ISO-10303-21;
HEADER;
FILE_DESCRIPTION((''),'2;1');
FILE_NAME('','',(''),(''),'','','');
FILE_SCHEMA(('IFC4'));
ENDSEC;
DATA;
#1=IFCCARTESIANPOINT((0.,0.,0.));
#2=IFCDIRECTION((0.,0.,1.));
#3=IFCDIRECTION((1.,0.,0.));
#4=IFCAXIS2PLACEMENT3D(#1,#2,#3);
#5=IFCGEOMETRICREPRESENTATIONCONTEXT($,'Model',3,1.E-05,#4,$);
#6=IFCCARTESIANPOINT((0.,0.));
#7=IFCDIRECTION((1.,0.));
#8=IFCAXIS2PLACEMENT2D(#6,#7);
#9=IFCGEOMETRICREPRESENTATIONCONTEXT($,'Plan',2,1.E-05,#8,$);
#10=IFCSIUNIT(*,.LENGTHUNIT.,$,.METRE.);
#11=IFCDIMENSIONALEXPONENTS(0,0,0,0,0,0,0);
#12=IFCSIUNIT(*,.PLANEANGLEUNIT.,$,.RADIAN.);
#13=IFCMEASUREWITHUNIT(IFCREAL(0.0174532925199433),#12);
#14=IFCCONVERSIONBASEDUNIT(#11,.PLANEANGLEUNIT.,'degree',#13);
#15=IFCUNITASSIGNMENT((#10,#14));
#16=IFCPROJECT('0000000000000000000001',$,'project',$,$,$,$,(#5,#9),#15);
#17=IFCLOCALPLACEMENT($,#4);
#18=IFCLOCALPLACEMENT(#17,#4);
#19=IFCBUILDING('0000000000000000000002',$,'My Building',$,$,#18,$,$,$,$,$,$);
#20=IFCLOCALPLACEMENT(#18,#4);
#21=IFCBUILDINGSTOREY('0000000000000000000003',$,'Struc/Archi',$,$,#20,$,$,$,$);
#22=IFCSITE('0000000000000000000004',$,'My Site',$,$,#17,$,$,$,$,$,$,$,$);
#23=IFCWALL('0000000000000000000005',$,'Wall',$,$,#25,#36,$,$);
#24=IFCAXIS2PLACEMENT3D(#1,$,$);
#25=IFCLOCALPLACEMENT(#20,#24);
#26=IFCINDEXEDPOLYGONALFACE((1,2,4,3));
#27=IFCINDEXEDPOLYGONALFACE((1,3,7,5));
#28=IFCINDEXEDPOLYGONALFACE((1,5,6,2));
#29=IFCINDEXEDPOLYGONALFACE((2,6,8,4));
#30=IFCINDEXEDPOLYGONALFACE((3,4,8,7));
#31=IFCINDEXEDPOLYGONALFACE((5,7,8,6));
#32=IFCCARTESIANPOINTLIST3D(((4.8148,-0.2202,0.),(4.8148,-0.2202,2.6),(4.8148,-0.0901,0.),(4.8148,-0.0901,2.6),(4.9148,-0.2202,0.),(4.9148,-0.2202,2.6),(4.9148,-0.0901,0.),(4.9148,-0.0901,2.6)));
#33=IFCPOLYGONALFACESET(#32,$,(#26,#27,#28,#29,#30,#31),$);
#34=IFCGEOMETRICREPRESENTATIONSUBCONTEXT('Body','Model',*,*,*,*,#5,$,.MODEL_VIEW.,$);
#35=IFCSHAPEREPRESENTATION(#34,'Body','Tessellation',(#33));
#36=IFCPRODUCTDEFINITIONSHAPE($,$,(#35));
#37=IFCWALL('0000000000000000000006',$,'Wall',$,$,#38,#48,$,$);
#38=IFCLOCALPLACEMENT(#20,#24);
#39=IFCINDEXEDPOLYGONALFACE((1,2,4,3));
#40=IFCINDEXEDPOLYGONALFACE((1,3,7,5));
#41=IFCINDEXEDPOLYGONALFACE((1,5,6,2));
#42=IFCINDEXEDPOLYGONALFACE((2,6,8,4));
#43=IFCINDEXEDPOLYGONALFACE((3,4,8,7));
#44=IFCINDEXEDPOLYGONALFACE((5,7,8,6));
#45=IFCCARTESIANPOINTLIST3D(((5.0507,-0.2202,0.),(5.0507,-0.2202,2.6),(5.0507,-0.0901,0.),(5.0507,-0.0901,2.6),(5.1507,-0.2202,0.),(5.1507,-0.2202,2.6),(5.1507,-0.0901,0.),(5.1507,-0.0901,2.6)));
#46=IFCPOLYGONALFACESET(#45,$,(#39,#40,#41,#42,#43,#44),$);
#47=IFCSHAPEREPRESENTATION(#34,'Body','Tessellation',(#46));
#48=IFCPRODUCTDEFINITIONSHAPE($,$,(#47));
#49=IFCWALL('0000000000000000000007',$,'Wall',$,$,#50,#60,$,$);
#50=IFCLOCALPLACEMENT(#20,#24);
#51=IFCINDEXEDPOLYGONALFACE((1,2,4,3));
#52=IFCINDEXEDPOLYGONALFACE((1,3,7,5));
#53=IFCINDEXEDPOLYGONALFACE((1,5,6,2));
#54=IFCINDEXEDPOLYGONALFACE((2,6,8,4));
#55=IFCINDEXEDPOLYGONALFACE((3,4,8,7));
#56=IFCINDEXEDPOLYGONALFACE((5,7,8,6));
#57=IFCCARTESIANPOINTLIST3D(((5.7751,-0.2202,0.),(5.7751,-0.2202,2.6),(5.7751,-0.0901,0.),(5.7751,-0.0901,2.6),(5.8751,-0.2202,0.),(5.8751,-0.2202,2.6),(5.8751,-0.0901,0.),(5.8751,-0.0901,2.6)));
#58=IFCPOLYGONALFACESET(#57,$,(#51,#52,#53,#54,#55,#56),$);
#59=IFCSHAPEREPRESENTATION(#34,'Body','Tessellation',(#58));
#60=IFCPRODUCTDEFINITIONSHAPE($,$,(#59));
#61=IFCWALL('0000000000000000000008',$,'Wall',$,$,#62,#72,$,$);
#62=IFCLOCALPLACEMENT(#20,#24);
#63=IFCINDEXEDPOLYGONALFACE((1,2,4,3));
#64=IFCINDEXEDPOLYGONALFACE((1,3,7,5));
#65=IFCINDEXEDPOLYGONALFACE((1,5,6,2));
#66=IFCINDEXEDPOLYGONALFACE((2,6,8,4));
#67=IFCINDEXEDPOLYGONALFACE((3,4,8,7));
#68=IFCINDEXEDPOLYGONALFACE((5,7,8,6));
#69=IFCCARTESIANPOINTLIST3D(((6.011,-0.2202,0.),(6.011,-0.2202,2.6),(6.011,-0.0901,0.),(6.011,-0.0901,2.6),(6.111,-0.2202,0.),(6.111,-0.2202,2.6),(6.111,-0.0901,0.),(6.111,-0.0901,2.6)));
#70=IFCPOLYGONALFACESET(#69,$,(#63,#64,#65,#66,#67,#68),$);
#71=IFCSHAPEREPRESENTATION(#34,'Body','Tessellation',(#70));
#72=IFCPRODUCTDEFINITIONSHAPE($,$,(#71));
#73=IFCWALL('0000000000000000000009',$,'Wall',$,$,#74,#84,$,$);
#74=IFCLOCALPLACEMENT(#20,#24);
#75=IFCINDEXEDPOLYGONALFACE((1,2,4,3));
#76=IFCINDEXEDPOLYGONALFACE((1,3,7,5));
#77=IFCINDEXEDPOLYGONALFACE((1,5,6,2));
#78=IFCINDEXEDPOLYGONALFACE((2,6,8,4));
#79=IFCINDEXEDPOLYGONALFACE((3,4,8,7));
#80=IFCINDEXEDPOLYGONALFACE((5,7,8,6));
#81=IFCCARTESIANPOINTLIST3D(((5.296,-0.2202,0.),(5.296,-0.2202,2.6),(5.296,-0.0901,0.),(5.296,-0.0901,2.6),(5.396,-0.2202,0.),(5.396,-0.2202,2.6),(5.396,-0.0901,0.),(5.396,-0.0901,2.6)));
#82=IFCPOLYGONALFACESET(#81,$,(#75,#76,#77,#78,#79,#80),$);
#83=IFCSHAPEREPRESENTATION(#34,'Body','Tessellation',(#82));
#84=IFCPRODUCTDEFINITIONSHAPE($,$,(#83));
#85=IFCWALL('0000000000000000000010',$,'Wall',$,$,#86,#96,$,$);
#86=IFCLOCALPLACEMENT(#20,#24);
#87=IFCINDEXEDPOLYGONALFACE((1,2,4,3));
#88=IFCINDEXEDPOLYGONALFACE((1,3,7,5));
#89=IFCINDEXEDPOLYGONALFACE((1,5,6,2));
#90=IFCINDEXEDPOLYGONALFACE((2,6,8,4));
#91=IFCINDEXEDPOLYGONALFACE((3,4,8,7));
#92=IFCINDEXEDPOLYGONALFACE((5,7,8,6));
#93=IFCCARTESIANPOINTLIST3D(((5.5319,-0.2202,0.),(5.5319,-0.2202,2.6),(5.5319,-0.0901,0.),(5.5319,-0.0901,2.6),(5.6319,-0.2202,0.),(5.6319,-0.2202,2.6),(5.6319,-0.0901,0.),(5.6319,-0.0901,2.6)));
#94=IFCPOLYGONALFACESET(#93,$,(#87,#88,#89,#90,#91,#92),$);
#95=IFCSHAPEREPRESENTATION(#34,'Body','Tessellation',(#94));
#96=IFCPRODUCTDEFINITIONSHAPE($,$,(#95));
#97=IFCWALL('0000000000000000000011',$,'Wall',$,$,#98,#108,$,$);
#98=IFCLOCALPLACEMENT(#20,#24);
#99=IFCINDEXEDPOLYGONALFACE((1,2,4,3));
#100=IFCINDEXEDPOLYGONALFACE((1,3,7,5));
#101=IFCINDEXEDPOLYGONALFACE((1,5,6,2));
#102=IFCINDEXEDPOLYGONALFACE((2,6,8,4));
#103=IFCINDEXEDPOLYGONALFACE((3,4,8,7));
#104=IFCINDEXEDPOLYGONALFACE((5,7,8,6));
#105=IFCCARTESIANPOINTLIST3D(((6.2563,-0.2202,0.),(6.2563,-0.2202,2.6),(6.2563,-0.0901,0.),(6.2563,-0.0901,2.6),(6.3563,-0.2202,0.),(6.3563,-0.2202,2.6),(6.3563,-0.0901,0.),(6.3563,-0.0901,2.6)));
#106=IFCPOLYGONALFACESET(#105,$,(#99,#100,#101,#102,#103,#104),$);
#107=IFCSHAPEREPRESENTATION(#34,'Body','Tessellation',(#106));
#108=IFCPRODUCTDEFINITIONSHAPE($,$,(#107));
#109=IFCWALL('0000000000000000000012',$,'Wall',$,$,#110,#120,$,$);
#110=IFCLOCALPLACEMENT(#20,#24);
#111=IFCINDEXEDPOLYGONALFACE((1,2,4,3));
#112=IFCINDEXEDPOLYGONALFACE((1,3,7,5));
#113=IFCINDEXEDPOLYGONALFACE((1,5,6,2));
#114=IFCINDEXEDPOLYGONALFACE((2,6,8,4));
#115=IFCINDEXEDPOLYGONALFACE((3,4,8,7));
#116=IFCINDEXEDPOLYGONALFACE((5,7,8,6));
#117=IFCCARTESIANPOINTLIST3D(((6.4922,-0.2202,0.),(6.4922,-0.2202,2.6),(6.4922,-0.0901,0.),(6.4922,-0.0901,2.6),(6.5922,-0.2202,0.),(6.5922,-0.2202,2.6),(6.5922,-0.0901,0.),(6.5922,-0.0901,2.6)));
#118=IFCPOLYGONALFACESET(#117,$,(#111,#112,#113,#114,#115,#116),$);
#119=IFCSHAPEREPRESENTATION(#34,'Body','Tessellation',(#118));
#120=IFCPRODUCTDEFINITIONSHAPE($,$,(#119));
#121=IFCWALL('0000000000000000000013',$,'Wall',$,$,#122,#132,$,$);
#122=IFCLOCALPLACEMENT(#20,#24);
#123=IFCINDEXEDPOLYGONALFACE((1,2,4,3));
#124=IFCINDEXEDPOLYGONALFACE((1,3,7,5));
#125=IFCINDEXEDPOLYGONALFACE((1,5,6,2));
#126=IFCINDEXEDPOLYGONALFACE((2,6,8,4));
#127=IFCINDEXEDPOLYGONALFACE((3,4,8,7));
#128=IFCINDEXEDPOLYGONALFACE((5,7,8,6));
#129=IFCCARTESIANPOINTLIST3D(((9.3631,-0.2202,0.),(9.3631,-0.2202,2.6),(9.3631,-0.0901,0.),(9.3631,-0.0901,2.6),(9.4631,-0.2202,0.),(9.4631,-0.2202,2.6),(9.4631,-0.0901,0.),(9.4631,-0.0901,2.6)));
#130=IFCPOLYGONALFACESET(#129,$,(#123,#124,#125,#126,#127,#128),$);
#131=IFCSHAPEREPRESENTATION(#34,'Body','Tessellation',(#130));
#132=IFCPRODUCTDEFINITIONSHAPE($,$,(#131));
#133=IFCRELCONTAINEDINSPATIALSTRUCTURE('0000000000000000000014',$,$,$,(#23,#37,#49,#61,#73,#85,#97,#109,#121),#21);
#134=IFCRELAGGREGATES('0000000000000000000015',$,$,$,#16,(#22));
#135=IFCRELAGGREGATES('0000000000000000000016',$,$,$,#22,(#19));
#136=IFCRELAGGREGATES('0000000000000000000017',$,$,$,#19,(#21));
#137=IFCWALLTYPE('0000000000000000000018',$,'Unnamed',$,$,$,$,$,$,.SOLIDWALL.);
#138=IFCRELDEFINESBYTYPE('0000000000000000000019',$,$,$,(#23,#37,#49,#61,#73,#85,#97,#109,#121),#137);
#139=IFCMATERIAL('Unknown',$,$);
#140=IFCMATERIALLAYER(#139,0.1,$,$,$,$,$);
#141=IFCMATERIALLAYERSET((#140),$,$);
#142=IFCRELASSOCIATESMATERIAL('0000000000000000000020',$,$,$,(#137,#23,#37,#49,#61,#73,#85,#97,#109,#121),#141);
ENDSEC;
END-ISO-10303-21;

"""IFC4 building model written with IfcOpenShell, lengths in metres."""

from ifc_helpers import new_model, entity, si_unit, converted_unit, frame, origin_with_axes, origin_2d_with_axis, place, context, subcontext, project, spatial, line, indexed_curve, outline, extrude, material, layer, layer_set, layer_usage, type_object, element, save


model = new_model("IFC4")

# Units and contexts
model_context = context("Model", 3, precision=1e-05, world=origin_with_axes())
plan_context = context("Plan", 2, precision=1e-05, world=origin_2d_with_axis())
body_context_1 = subcontext(model_context, "Body", "Model", "MODEL_VIEW")
ifc_project = project(units=[si_unit("LENGTHUNIT", "METRE"), converted_unit("PLANEANGLEUNIT", "degree", entity("IfcReal", 0.0174532925199433), si_unit("PLANEANGLEUNIT", "RADIAN"), dimensions=[0, 0, 0, 0, 0, 0, 0])], contexts=[model_context, plan_context])

# Site, building, storey
site_placement = place(None, origin_with_axes())
site = spatial("IfcSite", under=ifc_project, at=site_placement, Name="My Site")
building_placement = place(site_placement, origin_with_axes())
building = spatial("IfcBuilding", under=site, at=building_placement, Name="My Building")
storey_placement = place(building_placement, origin_with_axes())
storey = spatial("IfcBuildingStorey", under=building, at=storey_placement, Name="Struc/Archi")

# Shared definitions
ifc_material = material(Name="Unknown")

# Shared definitions
ifc_layer_1 = layer(ifc_material, 0.1)
ifc_layer_set_1 = layer_set([ifc_layer_1])
wall_type = type_object("IfcWallType", Name="Unnamed", PredefinedType="SOLIDWALL", material=ifc_layer_set_1)

# Walls
ifc_layer_usage_1 = layer_usage(ifc_layer_set_1, "AXIS2", "POSITIVE", 0.0)
wall_1_placement = place(storey_placement, frame((4.8148, -0.0901, 0.0), z_axis=(0.0, 0.0, 1.0), x_axis=(0.0, -1.0, 0.0)))
element("IfcWall", 1, at=wall_1_placement, inside=storey, type_object=wall_type, material=ifc_layer_usage_1, Name="Wall", context=body_context_1, shape_type="SweptSolid", body=[
    extrude(outline(indexed_curve([(0.0, 0.0), (0.0, 0.1), (0.1301, 0.1), (0.1301, 0.0)], segments=[line(1, 2, 3, 4, 1)])), origin_with_axes(), (0.0, 0.0, 1.0), 2.6),
])
ifc_layer_usage_2 = layer_usage(ifc_layer_set_1, "AXIS2", "POSITIVE", 0.0)
wall_2_placement = place(storey_placement, frame((5.0507, -0.0901, 0.0), z_axis=(0.0, 0.0, 1.0), x_axis=(0.0, -1.0, 0.0)))
element("IfcWall", 2, at=wall_2_placement, inside=storey, type_object=wall_type, material=ifc_layer_usage_2, Name="Wall", context=body_context_1, shape_type="SweptSolid", body=[
    extrude(outline(indexed_curve([(0.0, 0.0), (0.0, 0.1), (0.1301, 0.1), (0.1301, 0.0)], segments=[line(1, 2, 3, 4, 1)])), origin_with_axes(), (0.0, 0.0, 1.0), 2.6),
])
ifc_layer_usage_3 = layer_usage(ifc_layer_set_1, "AXIS2", "POSITIVE", 0.0)
wall_3_placement = place(storey_placement, frame((5.7751, -0.0901, 0.0), z_axis=(0.0, 0.0, 1.0), x_axis=(0.0, -1.0, 0.0)))
element("IfcWall", 3, at=wall_3_placement, inside=storey, type_object=wall_type, material=ifc_layer_usage_3, Name="Wall", context=body_context_1, shape_type="SweptSolid", body=[
    extrude(outline(indexed_curve([(0.0, 0.0), (0.0, 0.1), (0.1301, 0.1), (0.1301, 0.0)], segments=[line(1, 2, 3, 4, 1)])), origin_with_axes(), (0.0, 0.0, 1.0), 2.6),
])
ifc_layer_usage_4 = layer_usage(ifc_layer_set_1, "AXIS2", "POSITIVE", 0.0)
wall_4_placement = place(storey_placement, frame((6.011, -0.0901, 0.0), z_axis=(0.0, 0.0, 1.0), x_axis=(0.0, -1.0, 0.0)))
element("IfcWall", 4, at=wall_4_placement, inside=storey, type_object=wall_type, material=ifc_layer_usage_4, Name="Wall", context=body_context_1, shape_type="SweptSolid", body=[
    extrude(outline(indexed_curve([(0.0, 0.0), (0.0, 0.1), (0.1301, 0.1), (0.1301, 0.0)], segments=[line(1, 2, 3, 4, 1)])), origin_with_axes(), (0.0, 0.0, 1.0), 2.6),
])
ifc_layer_usage_5 = layer_usage(ifc_layer_set_1, "AXIS2", "POSITIVE", 0.0)
wall_5_placement = place(storey_placement, frame((5.296, -0.0901, 0.0), z_axis=(0.0, 0.0, 1.0), x_axis=(0.0, -1.0, 0.0)))
element("IfcWall", 5, at=wall_5_placement, inside=storey, type_object=wall_type, material=ifc_layer_usage_5, Name="Wall", context=body_context_1, shape_type="SweptSolid", body=[
    extrude(outline(indexed_curve([(0.0, 0.0), (0.0, 0.1), (0.1301, 0.1), (0.1301, 0.0)], segments=[line(1, 2, 3, 4, 1)])), origin_with_axes(), (0.0, 0.0, 1.0), 2.6),
])
ifc_layer_usage_6 = layer_usage(ifc_layer_set_1, "AXIS2", "POSITIVE", 0.0)
wall_6_placement = place(storey_placement, frame((5.5319, -0.0901, 0.0), z_axis=(0.0, 0.0, 1.0), x_axis=(0.0, -1.0, 0.0)))
element("IfcWall", 6, at=wall_6_placement, inside=storey, type_object=wall_type, material=ifc_layer_usage_6, Name="Wall", context=body_context_1, shape_type="SweptSolid", body=[
    extrude(outline(indexed_curve([(0.0, 0.0), (0.0, 0.1), (0.1301, 0.1), (0.1301, 0.0)], segments=[line(1, 2, 3, 4, 1)])), origin_with_axes(), (0.0, 0.0, 1.0), 2.6),
])
ifc_layer_usage_7 = layer_usage(ifc_layer_set_1, "AXIS2", "POSITIVE", 0.0)
wall_7_placement = place(storey_placement, frame((6.2563, -0.0901, 0.0), z_axis=(0.0, 0.0, 1.0), x_axis=(0.0, -1.0, 0.0)))
element("IfcWall", 7, at=wall_7_placement, inside=storey, type_object=wall_type, material=ifc_layer_usage_7, Name="Wall", context=body_context_1, shape_type="SweptSolid", body=[
    extrude(outline(indexed_curve([(0.0, 0.0), (0.0, 0.1), (0.1301, 0.1), (0.1301, 0.0)], segments=[line(1, 2, 3, 4, 1)])), origin_with_axes(), (0.0, 0.0, 1.0), 2.6),
])
ifc_layer_usage_8 = layer_usage(ifc_layer_set_1, "AXIS2", "POSITIVE", 0.0)
wall_8_placement = place(storey_placement, frame((6.4922, -0.0901, 0.0), z_axis=(0.0, 0.0, 1.0), x_axis=(0.0, -1.0, 0.0)))
element("IfcWall", 8, at=wall_8_placement, inside=storey, type_object=wall_type, material=ifc_layer_usage_8, Name="Wall", context=body_context_1, shape_type="SweptSolid", body=[
    extrude(outline(indexed_curve([(0.0, 0.0), (0.0, 0.1), (0.1301, 0.1), (0.1301, 0.0)], segments=[line(1, 2, 3, 4, 1)])), origin_with_axes(), (0.0, 0.0, 1.0), 2.6),
])
ifc_layer_usage_9 = layer_usage(ifc_layer_set_1, "AXIS2", "POSITIVE", 0.0)
wall_9_placement = place(storey_placement, frame((9.3631, -0.0901, 0.0), z_axis=(0.0, 0.0, 1.0), x_axis=(0.0, -1.0, 0.0)))
element("IfcWall", 9, at=wall_9_placement, inside=storey, type_object=wall_type, material=ifc_layer_usage_9, Name="Wall", context=body_context_1, shape_type="SweptSolid", body=[
    extrude(outline(indexed_curve([(0.0, 0.0), (0.0, 0.1), (0.1301, 0.1), (0.1301, 0.0)], segments=[line(1, 2, 3, 4, 1)])), origin_with_axes(), (0.0, 0.0, 1.0), 2.6),
])

save(model, "model.ifc")
